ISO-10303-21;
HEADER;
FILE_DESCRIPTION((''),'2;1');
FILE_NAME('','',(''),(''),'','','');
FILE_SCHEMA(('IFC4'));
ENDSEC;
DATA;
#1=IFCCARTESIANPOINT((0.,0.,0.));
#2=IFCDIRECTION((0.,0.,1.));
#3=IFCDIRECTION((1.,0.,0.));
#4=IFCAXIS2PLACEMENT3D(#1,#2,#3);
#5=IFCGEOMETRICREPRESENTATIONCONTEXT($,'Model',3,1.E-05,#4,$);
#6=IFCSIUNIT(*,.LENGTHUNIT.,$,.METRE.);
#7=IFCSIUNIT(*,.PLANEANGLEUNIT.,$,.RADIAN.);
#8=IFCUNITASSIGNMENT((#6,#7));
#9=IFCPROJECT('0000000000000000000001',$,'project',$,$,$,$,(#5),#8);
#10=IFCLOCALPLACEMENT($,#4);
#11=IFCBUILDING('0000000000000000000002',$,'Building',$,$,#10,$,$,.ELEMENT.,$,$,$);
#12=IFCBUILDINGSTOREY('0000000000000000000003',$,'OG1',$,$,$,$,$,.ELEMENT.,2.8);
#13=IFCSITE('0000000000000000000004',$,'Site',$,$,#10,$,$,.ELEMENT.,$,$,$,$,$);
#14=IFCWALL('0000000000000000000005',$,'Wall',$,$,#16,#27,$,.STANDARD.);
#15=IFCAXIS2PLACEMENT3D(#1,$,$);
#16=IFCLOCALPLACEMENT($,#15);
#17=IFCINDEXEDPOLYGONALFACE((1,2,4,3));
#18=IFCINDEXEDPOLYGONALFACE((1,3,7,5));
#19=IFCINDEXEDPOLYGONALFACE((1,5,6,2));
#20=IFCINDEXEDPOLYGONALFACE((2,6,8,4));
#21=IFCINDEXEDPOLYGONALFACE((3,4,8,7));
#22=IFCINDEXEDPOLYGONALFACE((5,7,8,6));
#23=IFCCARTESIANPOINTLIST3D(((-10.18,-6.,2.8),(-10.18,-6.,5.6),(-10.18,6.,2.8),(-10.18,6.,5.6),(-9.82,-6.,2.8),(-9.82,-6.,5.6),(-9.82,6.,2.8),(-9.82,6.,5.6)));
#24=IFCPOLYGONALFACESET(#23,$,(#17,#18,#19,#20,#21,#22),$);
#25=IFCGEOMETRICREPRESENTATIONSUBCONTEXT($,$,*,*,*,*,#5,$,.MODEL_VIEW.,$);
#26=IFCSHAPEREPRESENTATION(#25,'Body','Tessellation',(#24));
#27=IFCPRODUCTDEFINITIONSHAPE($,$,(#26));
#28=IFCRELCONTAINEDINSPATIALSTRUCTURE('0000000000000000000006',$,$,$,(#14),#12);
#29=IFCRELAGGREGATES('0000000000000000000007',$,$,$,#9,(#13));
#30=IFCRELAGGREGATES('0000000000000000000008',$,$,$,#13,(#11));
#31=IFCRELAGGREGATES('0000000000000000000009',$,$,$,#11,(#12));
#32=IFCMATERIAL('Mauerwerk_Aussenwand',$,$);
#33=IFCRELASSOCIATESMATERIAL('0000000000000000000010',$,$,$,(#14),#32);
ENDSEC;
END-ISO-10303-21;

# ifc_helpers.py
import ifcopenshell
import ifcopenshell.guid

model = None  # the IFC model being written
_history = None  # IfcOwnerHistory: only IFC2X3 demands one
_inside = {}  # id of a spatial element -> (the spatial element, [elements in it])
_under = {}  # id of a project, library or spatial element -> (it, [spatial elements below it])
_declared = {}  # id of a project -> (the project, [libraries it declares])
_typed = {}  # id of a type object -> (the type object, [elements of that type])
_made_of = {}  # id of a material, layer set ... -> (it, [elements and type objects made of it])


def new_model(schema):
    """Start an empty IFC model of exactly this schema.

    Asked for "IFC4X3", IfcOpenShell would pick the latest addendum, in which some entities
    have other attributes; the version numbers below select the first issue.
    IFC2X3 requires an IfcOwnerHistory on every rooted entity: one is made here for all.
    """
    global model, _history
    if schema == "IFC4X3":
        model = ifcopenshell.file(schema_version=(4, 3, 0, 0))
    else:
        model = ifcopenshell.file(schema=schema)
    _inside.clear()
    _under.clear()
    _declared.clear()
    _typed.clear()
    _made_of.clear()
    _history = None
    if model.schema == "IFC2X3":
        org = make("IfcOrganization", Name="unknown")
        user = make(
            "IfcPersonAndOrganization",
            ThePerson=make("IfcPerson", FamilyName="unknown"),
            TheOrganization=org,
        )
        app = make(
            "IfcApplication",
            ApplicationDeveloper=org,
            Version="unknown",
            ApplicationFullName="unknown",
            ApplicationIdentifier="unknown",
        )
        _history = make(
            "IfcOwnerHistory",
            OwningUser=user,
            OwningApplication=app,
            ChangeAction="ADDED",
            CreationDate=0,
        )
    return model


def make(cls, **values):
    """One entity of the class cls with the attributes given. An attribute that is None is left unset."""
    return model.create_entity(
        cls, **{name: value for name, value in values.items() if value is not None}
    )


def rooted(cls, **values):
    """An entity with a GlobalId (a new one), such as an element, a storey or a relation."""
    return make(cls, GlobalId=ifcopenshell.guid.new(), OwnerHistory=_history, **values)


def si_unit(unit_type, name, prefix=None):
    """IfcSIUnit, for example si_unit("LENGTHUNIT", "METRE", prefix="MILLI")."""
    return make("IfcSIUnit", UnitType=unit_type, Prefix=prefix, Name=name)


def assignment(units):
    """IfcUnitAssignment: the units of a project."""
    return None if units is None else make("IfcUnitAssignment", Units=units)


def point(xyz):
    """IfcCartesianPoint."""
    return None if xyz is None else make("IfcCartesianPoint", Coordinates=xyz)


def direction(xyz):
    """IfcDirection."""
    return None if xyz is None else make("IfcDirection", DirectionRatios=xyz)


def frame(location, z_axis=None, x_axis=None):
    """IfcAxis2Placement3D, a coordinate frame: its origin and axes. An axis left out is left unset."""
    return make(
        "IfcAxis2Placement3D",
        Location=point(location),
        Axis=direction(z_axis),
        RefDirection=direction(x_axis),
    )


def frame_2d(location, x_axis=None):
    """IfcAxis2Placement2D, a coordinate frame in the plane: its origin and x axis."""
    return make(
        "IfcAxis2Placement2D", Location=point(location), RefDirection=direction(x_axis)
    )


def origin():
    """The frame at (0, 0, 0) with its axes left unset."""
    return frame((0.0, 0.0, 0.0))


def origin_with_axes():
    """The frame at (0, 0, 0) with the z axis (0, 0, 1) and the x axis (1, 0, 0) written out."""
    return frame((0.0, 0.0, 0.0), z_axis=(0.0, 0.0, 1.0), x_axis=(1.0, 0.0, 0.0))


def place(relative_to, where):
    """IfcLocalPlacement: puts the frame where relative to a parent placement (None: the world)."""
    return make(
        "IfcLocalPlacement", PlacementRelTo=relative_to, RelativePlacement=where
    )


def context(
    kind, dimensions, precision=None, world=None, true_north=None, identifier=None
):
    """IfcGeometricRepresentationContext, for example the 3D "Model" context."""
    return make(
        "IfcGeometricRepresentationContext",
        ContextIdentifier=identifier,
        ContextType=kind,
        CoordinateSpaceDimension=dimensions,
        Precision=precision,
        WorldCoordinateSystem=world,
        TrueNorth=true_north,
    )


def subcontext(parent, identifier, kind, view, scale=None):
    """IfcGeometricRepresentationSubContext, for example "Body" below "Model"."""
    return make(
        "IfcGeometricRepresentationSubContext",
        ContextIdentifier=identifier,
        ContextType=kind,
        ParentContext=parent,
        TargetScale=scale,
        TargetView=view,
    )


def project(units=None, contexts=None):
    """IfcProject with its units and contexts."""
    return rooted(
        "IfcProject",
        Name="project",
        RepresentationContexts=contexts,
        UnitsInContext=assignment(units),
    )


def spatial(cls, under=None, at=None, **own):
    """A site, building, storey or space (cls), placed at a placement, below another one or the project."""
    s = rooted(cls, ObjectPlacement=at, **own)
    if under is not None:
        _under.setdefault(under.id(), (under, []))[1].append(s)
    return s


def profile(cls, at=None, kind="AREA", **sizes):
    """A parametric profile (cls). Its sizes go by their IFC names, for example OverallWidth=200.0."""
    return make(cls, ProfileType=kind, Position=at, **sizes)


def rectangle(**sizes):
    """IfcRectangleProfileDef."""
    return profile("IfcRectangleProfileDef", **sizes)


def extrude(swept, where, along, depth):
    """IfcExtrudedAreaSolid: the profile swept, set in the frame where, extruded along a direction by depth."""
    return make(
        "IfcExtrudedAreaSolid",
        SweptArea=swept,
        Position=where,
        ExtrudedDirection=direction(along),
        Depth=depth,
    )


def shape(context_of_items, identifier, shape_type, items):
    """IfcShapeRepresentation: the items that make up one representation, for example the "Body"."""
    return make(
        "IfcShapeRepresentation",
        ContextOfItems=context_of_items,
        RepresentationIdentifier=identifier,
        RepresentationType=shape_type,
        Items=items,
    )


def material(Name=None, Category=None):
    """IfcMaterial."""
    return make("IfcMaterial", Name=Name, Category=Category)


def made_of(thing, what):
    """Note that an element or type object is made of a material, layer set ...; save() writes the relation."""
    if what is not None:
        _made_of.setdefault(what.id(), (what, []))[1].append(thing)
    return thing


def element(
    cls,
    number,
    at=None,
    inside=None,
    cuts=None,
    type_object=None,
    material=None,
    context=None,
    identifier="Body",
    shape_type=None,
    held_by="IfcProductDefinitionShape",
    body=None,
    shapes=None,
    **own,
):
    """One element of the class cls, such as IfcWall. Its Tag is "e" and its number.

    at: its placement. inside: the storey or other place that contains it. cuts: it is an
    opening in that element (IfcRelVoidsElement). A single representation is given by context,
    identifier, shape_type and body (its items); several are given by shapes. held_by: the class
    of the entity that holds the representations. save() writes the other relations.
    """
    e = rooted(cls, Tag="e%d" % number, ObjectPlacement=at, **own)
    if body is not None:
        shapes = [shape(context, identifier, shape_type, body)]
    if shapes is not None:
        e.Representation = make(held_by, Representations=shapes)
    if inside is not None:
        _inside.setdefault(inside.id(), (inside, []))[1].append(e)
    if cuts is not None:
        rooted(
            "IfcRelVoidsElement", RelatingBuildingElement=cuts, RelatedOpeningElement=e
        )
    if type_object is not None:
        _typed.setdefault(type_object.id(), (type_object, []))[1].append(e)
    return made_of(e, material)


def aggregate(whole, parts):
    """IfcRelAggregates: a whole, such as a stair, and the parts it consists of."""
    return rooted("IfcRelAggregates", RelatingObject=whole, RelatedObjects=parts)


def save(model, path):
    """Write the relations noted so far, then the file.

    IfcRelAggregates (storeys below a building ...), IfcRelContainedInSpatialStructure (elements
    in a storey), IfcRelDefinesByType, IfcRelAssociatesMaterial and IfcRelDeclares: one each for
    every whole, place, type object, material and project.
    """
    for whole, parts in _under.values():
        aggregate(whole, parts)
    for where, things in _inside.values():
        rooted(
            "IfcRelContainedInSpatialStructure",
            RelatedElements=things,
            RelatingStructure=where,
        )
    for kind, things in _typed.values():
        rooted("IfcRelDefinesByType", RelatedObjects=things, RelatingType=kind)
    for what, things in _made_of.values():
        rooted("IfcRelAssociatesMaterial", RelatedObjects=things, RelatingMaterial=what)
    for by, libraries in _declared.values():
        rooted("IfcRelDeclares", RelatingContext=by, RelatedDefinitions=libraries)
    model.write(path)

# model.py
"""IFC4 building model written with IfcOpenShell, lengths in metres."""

from ifc_helpers import new_model, si_unit, frame, frame_2d, origin, origin_with_axes, place, context, subcontext, project, spatial, rectangle, extrude, material, element, save


model = new_model("IFC4")

# Units and contexts
model_context = context("Model", 3, precision=1e-05, world=origin_with_axes())
sub_context = subcontext(model_context, None, None, "MODEL_VIEW")
ifc_project = project(units=[si_unit("LENGTHUNIT", "METRE"), si_unit("PLANEANGLEUNIT", "RADIAN")], contexts=[model_context])

# Site, building, storey
placement_1 = place(None, origin_with_axes())
site = spatial("IfcSite", under=ifc_project, at=placement_1, Name="Site", CompositionType="ELEMENT")
building = spatial("IfcBuilding", under=site, at=placement_1, Name="Building", CompositionType="ELEMENT")
storey = spatial("IfcBuildingStorey", under=building, Name="OG1", CompositionType="ELEMENT", Elevation=2.8)

# Wall
ifc_material = material(Name="Mauerwerk_Aussenwand")
placement_2 = place(None, origin_with_axes())
placement_3 = place(placement_2, frame((0.0, 0.0, 2.8)))
wall_placement = place(placement_3, frame((-10.0, -6.0, 0.0), x_axis=(0.0, 1.0, 0.0)))
element("IfcWall", 1, at=wall_placement, inside=storey, material=ifc_material, Name="Wall", PredefinedType="STANDARD", context=sub_context, shape_type="SweptSolid", body=[
    extrude(rectangle(XDim=12.0, YDim=0.36, at=frame_2d((6.0, 0.0))), origin(), (0.0, 0.0, 1.0), 2.8),
])

save(model, "model.ifc")
